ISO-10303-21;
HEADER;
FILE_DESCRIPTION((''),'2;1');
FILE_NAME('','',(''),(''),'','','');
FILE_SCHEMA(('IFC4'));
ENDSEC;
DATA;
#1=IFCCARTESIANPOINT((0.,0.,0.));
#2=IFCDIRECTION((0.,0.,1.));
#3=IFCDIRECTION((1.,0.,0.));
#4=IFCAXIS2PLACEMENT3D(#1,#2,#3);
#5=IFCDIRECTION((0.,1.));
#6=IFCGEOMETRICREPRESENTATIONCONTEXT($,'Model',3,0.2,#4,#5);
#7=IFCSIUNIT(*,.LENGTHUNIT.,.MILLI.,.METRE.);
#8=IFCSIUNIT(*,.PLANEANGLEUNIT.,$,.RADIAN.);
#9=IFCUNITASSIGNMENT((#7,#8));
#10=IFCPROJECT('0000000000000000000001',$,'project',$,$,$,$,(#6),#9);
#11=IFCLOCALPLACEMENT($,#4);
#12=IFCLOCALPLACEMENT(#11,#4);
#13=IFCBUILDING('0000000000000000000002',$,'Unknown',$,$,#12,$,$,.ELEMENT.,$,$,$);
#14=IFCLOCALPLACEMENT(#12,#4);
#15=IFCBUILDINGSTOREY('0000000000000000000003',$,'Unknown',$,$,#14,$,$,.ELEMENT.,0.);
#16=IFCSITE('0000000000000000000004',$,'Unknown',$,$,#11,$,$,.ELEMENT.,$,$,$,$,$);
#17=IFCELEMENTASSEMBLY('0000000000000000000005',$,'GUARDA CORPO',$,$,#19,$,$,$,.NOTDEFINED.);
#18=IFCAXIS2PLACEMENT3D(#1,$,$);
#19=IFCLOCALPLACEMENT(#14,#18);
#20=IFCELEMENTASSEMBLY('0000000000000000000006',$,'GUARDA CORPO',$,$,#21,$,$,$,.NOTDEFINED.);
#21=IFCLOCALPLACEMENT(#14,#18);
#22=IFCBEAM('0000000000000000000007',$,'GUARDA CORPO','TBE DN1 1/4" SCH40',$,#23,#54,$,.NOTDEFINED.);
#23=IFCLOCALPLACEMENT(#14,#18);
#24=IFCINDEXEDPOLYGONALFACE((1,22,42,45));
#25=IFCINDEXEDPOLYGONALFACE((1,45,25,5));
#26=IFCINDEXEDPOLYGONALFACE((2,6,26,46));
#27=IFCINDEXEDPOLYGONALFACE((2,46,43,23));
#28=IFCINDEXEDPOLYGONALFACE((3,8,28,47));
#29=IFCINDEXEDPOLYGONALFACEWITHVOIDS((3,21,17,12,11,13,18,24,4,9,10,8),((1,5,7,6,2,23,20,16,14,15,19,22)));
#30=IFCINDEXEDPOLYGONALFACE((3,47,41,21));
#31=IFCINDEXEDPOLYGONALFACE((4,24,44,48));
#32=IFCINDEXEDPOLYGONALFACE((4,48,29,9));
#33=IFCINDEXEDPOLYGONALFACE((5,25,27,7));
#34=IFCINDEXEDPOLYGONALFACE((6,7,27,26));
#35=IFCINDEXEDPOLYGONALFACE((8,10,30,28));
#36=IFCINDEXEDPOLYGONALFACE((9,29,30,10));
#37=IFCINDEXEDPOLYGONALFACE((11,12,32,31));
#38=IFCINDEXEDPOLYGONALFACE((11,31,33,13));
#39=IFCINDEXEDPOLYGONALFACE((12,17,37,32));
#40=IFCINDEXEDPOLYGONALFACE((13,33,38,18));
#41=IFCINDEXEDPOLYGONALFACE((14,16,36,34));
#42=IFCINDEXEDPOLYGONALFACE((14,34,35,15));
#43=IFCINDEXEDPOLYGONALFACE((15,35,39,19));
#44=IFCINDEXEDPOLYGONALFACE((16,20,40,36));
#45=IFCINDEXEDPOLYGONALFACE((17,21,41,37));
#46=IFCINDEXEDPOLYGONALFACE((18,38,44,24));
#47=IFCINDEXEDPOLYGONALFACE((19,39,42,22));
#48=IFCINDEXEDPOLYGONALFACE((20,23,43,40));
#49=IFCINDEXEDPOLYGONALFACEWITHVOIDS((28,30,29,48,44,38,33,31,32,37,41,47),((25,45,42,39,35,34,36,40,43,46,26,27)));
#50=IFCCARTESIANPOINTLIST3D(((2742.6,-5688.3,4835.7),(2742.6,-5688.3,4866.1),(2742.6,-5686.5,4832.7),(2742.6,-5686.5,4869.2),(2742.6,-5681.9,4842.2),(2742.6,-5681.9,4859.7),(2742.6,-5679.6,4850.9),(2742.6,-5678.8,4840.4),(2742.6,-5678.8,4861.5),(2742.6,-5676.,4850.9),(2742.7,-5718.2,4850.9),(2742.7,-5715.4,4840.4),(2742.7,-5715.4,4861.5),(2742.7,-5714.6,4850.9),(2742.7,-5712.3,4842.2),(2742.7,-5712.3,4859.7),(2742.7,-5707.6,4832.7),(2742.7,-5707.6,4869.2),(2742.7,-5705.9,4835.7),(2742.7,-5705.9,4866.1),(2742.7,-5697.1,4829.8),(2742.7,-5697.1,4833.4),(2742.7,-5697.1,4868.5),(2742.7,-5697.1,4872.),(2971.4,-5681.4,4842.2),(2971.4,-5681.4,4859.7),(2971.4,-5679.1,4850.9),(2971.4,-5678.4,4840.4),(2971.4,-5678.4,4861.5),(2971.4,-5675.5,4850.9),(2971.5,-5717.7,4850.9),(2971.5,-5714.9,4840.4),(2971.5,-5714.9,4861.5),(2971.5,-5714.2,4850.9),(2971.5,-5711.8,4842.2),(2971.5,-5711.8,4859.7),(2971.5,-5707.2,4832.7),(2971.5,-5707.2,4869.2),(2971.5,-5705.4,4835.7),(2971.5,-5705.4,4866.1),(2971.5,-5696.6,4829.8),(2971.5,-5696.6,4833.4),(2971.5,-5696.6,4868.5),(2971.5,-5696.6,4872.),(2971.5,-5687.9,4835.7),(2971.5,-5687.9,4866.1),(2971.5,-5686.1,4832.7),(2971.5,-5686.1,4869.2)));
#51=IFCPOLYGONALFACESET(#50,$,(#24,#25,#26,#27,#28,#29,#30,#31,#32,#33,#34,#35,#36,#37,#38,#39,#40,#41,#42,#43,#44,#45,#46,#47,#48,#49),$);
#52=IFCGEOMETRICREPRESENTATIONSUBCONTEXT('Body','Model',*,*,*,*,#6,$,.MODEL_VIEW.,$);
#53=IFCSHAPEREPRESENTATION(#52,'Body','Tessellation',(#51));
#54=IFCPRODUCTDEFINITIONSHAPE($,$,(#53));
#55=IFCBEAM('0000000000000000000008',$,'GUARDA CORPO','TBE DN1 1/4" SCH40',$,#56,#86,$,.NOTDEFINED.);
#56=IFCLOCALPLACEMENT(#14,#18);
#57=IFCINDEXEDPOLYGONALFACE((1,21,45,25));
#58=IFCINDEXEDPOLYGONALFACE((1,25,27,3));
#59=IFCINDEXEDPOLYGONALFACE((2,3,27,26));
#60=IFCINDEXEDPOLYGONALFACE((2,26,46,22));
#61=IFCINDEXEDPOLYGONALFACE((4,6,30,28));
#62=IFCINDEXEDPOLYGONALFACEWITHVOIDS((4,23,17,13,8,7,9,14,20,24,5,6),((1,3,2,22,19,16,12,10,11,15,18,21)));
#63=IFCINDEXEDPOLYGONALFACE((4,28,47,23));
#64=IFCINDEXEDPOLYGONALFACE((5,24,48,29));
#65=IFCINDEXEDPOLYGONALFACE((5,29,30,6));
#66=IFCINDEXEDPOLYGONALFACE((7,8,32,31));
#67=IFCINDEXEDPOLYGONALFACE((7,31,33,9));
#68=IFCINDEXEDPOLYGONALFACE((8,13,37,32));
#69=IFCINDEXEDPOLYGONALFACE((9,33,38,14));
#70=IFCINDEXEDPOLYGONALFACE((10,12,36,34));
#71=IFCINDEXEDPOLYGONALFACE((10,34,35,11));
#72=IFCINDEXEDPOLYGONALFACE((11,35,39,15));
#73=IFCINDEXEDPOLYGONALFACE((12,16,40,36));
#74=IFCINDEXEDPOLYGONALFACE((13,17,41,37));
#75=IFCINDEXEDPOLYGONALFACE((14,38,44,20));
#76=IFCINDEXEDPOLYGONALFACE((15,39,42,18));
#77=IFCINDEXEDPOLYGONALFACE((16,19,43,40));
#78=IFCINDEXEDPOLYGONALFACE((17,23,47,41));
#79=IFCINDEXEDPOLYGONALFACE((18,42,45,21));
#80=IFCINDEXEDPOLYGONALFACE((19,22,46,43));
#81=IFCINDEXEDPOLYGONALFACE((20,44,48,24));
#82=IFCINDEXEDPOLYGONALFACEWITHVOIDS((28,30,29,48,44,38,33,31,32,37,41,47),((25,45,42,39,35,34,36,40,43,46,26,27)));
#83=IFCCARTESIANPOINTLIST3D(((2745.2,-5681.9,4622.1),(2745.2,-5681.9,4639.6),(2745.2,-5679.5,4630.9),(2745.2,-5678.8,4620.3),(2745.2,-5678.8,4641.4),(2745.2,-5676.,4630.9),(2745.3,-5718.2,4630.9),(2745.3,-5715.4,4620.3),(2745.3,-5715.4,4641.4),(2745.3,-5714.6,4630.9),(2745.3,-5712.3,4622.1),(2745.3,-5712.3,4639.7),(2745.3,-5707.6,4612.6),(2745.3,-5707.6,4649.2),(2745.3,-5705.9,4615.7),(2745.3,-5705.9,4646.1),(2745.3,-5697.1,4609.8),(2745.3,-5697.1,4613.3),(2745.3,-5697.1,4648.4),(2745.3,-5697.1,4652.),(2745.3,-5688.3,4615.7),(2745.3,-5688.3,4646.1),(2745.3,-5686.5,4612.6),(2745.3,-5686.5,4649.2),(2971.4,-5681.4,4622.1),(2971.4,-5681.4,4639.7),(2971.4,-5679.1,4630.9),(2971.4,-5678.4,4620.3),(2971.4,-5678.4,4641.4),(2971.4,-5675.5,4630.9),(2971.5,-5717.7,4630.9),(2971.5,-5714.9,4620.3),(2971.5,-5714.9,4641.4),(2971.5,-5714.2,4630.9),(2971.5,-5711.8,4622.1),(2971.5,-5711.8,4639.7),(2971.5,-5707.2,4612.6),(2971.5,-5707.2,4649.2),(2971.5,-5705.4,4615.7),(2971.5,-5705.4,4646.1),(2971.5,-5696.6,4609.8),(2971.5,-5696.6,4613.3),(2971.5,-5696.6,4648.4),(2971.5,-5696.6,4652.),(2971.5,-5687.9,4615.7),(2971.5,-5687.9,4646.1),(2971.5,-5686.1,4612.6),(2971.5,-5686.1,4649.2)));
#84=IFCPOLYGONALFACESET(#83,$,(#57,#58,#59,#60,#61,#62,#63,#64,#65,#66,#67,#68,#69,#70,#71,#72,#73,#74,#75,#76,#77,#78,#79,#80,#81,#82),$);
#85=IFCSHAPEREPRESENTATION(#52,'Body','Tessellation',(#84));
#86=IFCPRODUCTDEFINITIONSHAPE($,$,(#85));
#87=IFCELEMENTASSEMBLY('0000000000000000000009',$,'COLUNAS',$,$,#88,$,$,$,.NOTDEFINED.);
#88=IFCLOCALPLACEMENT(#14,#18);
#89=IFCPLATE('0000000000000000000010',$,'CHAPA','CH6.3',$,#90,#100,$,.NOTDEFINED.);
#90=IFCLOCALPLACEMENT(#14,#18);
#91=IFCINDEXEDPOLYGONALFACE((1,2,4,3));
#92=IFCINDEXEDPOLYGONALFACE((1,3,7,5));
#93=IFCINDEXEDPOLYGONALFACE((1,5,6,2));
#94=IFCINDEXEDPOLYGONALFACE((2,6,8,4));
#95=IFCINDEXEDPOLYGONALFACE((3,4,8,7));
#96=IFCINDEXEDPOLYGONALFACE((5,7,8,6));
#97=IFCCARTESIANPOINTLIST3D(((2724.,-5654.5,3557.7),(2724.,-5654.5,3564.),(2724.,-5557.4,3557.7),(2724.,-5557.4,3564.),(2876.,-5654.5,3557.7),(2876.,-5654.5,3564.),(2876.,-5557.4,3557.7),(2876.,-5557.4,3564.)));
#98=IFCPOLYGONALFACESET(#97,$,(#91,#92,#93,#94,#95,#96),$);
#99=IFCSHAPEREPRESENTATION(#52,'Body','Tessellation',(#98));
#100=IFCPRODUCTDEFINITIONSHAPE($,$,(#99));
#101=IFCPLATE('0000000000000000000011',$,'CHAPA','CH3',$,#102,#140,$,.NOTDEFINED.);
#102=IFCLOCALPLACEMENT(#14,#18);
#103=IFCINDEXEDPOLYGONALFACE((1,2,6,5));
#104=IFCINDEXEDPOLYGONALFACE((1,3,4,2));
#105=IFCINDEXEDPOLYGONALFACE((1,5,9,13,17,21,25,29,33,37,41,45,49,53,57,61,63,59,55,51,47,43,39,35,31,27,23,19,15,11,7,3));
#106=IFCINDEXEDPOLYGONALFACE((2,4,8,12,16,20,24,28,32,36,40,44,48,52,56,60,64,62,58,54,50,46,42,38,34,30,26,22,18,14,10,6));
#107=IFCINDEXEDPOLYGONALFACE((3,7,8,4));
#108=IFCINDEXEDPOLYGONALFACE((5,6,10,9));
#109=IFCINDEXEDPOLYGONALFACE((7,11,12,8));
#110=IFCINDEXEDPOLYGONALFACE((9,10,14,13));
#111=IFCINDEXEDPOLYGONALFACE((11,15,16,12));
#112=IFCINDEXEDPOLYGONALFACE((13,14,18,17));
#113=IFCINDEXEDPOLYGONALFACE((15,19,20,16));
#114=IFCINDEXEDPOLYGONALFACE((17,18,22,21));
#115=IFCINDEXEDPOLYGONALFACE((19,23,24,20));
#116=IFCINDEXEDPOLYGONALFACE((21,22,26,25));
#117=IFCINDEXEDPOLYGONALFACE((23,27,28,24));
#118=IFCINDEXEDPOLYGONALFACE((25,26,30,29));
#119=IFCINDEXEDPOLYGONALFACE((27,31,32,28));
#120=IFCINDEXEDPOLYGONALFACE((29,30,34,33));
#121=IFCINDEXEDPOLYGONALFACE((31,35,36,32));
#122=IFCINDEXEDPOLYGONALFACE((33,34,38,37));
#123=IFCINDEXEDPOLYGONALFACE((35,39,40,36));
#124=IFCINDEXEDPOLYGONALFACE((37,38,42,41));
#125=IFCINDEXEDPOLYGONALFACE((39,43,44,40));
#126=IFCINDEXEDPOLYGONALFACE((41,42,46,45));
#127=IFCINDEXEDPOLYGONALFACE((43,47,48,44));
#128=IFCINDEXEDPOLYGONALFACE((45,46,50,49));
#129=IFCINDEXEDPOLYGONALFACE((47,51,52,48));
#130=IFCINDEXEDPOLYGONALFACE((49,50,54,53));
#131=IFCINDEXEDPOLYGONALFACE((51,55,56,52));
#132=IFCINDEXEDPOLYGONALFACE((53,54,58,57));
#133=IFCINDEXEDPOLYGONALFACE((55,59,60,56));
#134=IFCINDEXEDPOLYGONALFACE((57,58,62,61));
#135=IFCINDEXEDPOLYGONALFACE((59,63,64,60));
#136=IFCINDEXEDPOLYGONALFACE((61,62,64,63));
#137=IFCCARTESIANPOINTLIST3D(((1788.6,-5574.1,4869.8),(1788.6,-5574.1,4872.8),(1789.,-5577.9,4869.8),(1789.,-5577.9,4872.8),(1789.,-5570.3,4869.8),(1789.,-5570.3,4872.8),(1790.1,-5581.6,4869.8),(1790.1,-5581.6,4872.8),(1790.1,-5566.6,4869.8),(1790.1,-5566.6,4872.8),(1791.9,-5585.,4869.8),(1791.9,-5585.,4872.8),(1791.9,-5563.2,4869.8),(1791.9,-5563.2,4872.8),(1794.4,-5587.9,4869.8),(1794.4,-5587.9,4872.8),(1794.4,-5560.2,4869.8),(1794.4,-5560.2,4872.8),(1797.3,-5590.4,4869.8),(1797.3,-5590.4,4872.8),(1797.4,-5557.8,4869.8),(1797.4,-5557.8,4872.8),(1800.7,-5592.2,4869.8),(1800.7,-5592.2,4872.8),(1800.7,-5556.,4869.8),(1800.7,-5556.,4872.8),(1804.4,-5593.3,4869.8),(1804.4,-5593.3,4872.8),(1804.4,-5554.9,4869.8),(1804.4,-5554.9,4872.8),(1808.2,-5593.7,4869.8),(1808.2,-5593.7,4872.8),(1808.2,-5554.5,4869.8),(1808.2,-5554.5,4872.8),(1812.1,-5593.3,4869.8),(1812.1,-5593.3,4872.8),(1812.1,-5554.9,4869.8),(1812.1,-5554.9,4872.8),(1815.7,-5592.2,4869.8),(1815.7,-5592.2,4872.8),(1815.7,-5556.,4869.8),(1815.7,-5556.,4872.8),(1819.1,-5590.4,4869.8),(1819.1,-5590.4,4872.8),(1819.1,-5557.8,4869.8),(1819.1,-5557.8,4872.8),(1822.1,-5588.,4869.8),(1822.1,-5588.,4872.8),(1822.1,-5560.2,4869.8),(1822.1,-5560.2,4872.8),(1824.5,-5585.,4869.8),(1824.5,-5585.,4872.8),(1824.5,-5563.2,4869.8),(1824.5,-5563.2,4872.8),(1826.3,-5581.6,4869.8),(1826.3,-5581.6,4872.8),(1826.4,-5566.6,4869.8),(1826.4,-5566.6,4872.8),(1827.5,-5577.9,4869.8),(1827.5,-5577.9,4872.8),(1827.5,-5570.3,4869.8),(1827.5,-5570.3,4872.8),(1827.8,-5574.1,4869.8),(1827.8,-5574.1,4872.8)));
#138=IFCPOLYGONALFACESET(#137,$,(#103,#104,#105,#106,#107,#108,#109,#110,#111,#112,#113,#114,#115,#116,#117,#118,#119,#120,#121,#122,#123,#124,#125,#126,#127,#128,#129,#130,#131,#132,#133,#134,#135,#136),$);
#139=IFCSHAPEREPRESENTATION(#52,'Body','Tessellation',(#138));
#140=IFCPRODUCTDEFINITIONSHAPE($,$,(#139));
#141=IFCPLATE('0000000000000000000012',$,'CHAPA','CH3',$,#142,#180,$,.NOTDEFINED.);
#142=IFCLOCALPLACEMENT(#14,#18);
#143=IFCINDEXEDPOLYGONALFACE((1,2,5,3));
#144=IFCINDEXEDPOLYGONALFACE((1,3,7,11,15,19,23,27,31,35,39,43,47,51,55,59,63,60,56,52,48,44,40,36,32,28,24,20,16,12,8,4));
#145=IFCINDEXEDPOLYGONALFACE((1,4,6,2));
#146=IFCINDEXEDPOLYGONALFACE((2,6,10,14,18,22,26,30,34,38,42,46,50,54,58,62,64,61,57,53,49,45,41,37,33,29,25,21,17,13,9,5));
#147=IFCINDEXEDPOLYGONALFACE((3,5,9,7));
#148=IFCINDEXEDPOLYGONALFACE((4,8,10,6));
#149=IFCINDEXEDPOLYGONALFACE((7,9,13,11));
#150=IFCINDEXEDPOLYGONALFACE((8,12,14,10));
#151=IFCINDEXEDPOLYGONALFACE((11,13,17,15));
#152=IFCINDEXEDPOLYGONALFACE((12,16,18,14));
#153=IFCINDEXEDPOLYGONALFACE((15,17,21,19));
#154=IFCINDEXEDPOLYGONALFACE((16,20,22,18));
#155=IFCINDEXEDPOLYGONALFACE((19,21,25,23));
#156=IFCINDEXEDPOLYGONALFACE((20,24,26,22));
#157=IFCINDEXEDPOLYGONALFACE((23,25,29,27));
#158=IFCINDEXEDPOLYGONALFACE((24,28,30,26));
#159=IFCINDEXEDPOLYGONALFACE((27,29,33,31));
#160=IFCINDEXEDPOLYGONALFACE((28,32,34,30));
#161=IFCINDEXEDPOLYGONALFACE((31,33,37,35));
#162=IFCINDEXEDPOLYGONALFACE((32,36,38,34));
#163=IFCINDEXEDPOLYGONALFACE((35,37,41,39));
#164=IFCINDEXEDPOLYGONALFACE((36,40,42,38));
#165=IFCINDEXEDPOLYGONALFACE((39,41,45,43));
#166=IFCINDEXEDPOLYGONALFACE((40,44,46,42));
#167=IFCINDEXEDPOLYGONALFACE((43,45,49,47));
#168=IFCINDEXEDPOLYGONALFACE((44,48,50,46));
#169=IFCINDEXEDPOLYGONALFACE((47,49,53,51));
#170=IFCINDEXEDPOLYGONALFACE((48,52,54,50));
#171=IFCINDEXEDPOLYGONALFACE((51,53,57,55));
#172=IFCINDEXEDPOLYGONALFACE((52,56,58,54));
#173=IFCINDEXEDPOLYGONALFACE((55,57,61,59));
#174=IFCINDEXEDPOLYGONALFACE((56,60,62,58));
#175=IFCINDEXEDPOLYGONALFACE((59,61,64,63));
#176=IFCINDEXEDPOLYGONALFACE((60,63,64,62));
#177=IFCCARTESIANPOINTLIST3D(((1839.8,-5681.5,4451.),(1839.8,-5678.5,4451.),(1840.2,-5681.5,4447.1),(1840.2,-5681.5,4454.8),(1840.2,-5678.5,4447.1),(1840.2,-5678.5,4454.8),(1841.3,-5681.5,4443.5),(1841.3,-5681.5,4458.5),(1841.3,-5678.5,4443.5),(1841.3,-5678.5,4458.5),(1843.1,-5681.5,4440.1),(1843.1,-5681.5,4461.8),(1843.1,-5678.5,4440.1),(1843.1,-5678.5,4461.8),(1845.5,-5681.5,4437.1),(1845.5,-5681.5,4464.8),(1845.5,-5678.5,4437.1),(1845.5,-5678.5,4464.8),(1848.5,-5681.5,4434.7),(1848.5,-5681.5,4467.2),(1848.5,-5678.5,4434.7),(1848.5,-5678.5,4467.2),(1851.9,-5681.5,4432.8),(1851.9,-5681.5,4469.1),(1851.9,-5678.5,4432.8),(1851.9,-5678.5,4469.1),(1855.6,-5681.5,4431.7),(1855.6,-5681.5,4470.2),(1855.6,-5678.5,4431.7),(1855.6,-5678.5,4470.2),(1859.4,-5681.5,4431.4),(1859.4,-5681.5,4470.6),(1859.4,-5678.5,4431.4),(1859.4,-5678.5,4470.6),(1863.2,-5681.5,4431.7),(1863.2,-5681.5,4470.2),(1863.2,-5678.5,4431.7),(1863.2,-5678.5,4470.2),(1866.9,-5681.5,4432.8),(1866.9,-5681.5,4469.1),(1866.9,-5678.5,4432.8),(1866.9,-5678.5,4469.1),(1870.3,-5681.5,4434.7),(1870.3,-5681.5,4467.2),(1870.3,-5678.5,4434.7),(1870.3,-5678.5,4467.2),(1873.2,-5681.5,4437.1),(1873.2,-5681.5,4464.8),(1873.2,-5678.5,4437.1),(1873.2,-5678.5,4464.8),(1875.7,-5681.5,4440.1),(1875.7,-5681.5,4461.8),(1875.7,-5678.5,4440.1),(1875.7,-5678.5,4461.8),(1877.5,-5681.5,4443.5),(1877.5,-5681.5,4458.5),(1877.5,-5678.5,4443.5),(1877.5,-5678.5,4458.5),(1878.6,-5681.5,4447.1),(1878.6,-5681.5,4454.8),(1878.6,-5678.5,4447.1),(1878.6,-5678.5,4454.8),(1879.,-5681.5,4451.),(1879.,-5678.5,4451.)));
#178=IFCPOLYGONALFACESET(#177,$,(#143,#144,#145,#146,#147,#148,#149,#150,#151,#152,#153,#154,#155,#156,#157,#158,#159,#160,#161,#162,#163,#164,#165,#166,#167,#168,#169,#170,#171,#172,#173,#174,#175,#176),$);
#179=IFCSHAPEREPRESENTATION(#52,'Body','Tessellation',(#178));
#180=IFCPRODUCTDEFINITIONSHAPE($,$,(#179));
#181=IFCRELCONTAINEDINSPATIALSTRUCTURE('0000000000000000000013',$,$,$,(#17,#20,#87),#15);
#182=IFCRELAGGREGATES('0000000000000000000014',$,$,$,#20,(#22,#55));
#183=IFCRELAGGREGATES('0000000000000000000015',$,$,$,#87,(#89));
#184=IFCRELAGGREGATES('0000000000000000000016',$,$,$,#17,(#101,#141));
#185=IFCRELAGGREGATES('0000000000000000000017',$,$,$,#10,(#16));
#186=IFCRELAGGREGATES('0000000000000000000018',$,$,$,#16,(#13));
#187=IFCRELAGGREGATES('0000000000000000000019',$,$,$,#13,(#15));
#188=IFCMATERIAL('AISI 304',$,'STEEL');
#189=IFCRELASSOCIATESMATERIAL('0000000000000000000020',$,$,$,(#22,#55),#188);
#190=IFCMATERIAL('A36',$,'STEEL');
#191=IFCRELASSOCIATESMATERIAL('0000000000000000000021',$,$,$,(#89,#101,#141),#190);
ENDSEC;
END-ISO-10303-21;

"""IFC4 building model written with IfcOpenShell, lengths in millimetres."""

from ifc_helpers import new_model, si_unit, direction, frame, origin_with_axes, place, context, subcontext, project, spatial, line, indexed_curve, outline, extrude, material, element, aggregate, save


model = new_model("IFC4")

# Units and contexts
model_context = context("Model", 3, precision=0.2, world=origin_with_axes(), true_north=direction((0.0, 1.0)))
body_context = subcontext(model_context, "Body", "Model", "MODEL_VIEW")
ifc_project = project(units=[si_unit("LENGTHUNIT", "METRE", prefix="MILLI"), si_unit("PLANEANGLEUNIT", "RADIAN")], contexts=[model_context])

# Site, building, storey
site_placement = place(None, origin_with_axes())
site = spatial("IfcSite", under=ifc_project, at=site_placement, Name="Unknown", CompositionType="ELEMENT")
building_placement = place(site_placement, origin_with_axes())
building = spatial("IfcBuilding", under=site, at=building_placement, Name="Unknown", CompositionType="ELEMENT")
storey_placement = place(building_placement, origin_with_axes())
storey = spatial("IfcBuildingStorey", under=building, at=storey_placement, Name="Unknown", CompositionType="ELEMENT", Elevation=0.0)

# Element assemblies, beams
ifc_material_1 = material(Name="A36", Category="STEEL")
assembly_1_placement = place(storey_placement, frame((647.5, -5181.6, 2875.0), z_axis=(-0.000512, 1.0, -0.000003), x_axis=(0.000003, 0.000003, 1.0)))
assembly_1 = element("IfcElementAssembly", 1, at=assembly_1_placement, inside=storey, Name="GUARDA CORPO", PredefinedType="NOTDEFINED")
ifc_material_2 = material(Name="AISI 304", Category="STEEL")
assembly_2_placement = place(storey_placement, frame((2908.2, -5645.6, 3955.0), z_axis=(0.000512, -1.0, -0.000003), x_axis=(0.000003, -0.000003, 1.0)))
assembly_2 = element("IfcElementAssembly", 2, at=assembly_2_placement, inside=storey, Name="GUARDA CORPO", PredefinedType="NOTDEFINED")
beam_1_placement = place(assembly_2_placement, frame((895.9, 165.5, 51.4), z_axis=(-0.000008, 0.001537, -0.999999), x_axis=(0.000004, -0.999999, -0.001537)))
beam_1 = element("IfcBeam", 3, at=beam_1_placement, material=ifc_material_2, Name="GUARDA CORPO", Description="TBE DN1 1/4\" SCH40", PredefinedType="NOTDEFINED", context=body_context, shape_type="SolidModel", body=[
    extrude(outline(indexed_curve([(21.1, 0.0), (18.3, 10.6), (10.6, 18.3), (0.0, 21.1), (-10.6, 18.3), (-18.3, 10.6), (-21.1, 0.0), (-18.3, -10.6), (-10.6, -18.3), (0.0, -21.1), (10.6, -18.3), (18.3, -10.6)], segments=[line(1, 2, 3, 4, 5, 6, 7, 8, 9, 10, 11, 12, 1)]), holes=[indexed_curve([(17.5, 0.0), (15.2, -8.8), (8.8, -15.2), (0.0, -17.5), (-8.8, -15.2), (-15.2, -8.8), (-17.5, 0.0), (-15.2, 8.8), (-8.8, 15.2), (0.0, 17.5), (8.8, 15.2), (15.2, 8.8)], segments=[line(1, 2, 3, 4, 5, 6, 7, 8, 9, 10, 11, 12, 1)])]), frame((0.0, 0.0, 0.0), z_axis=(-1.0, 0.0, 0.0), x_axis=(0.0, 0.0, 1.0)), (0.0, 0.0, -1.0), 228.8),
])
beam_2_placement = place(assembly_2_placement, frame((675.9, 162.9, 51.4), z_axis=(-0.000008, 0.001537, -0.999999), x_axis=(0.000004, -0.999999, -0.001537)))
beam_2 = element("IfcBeam", 4, at=beam_2_placement, material=ifc_material_2, Name="GUARDA CORPO", Description="TBE DN1 1/4\" SCH40", PredefinedType="NOTDEFINED", context=body_context, shape_type="SolidModel", body=[
    extrude(outline(indexed_curve([(21.1, 0.0), (18.3, 10.6), (10.6, 18.3), (0.0, 21.1), (-10.6, 18.3), (-18.3, 10.6), (-21.1, 0.0), (-18.3, -10.6), (-10.6, -18.3), (0.0, -21.1), (10.6, -18.3), (18.3, -10.6)], segments=[line(1, 2, 3, 4, 5, 6, 7, 8, 9, 10, 11, 12, 1)]), holes=[indexed_curve([(17.5, 0.0), (15.2, -8.8), (8.8, -15.2), (0.0, -17.5), (-8.8, -15.2), (-15.2, -8.8), (-17.5, 0.0), (-15.2, 8.8), (-8.8, 15.2), (0.0, 17.5), (8.8, 15.2), (15.2, 8.8)], segments=[line(1, 2, 3, 4, 5, 6, 7, 8, 9, 10, 11, 12, 1)])]), frame((0.0, 0.0, 0.0), z_axis=(-1.0, 0.0, 0.0), x_axis=(0.0, 0.0, 1.0)), (0.0, 0.0, -1.0), 226.2),
])
aggregate(assembly_2, [beam_1, beam_2])

# Element assembly, plate
assembly_3_placement = place(storey_placement, frame((2800.0, -5581.0, 3557.7), z_axis=(-1.0, 0.0, 0.0), x_axis=(0.0, 0.0, -1.0)))
assembly_3 = element("IfcElementAssembly", 5, at=assembly_3_placement, inside=storey, Name="COLUNAS", PredefinedType="NOTDEFINED")
plate_1_placement = place(assembly_3_placement, frame((-3.1, -23.6, 76.0), z_axis=(-1.0, 0.0, 0.0), x_axis=(0.0, 1.0, 0.0)))
plate_1 = element("IfcPlate", 6, at=plate_1_placement, material=ifc_material_1, Name="CHAPA", Description="CH6.3", PredefinedType="NOTDEFINED", context=body_context, shape_type="SolidModel", body=[
    extrude(outline(indexed_curve([(0.0, 0.0), (97.1, 0.0), (97.1, 152.0), (0.0, 152.0)], segments=[line(1, 2, 3, 4, 1)])), frame((0.0, 0.0, 3.1), z_axis=(0.0, 0.0, 1.0), x_axis=(1.0, 0.0, 0.0)), (0.0, 0.0, -1.0), 6.3),
])
aggregate(assembly_3, [plate_1])

# Plates
plate_2_placement = place(assembly_1_placement, frame((1996.3, 1164.3, -412.3), z_axis=(1.0, 0.0, 0.0), x_axis=(0.0, 0.957237, 0.289304)))
plate_2 = element("IfcPlate", 7, at=plate_2_placement, material=ifc_material_1, Name="CHAPA", Description="CH3", PredefinedType="NOTDEFINED", context=body_context, shape_type="SolidModel", body=[
    extrude(outline(indexed_curve([(0.0, 0.0), (3.8, 0.0), (7.6, 0.7), (11.2, 2.2), (14.4, 4.4), (17.1, 7.1), (19.2, 10.3), (20.7, 13.8), (21.4, 17.6), (21.4, 21.4), (20.7, 25.2), (19.2, 28.7), (17.1, 31.9), (14.4, 34.7), (11.2, 36.8), (7.6, 38.3), (3.8, 39.0), (0.0, 39.0), (-3.8, 38.3), (-7.3, 36.8), (-10.5, 34.7), (-13.2, 31.9), (-15.4, 28.7), (-16.8, 25.2), (-17.6, 21.4), (-17.6, 17.6), (-16.8, 13.8), (-15.4, 10.3), (-13.2, 7.1), (-10.5, 4.4), (-7.3, 2.2), (-3.8, 0.7)], segments=[line(1, 2, 3, 4, 5, 6, 7, 8, 9, 10, 11, 12, 13, 14, 15, 16, 17, 18, 19, 20, 21, 22, 23, 24, 25, 26, 27, 28, 29, 30, 31, 32, 1)])), frame((0.0, 0.0, 1.5), z_axis=(0.0, 0.0, 1.0), x_axis=(1.0, 0.0, 0.0)), (0.0, 0.0, -1.0), 3.0),
])
plate_3_placement = place(assembly_1_placement, frame((1556.7, 1215.4, -499.0), z_axis=(-0.000004, -0.000512, -1.0), x_axis=(0.290288, 0.956939, -0.000492)))
plate_3 = element("IfcPlate", 8, at=plate_3_placement, material=ifc_material_1, Name="CHAPA", Description="CH3", PredefinedType="NOTDEFINED", context=body_context, shape_type="SolidModel", body=[
    extrude(outline(indexed_curve([(0.0, 0.0), (3.8, 0.0), (7.6, 0.7), (11.2, 2.2), (14.4, 4.4), (17.1, 7.1), (19.2, 10.3), (20.7, 13.8), (21.4, 17.6), (21.4, 21.4), (20.7, 25.2), (19.2, 28.7), (17.1, 31.9), (14.4, 34.7), (11.2, 36.8), (7.6, 38.3), (3.8, 39.0), (0.0, 39.0), (-3.8, 38.3), (-7.3, 36.8), (-10.5, 34.7), (-13.2, 31.9), (-15.4, 28.7), (-16.8, 25.2), (-17.6, 21.4), (-17.6, 17.6), (-16.8, 13.8), (-15.4, 10.3), (-13.2, 7.1), (-10.5, 4.4), (-7.3, 2.2), (-3.8, 0.7)], segments=[line(1, 2, 3, 4, 5, 6, 7, 8, 9, 10, 11, 12, 13, 14, 15, 16, 17, 18, 19, 20, 21, 22, 23, 24, 25, 26, 27, 28, 29, 30, 31, 32, 1)])), frame((0.0, 0.0, 1.5), z_axis=(0.0, 0.0, 1.0), x_axis=(1.0, 0.0, 0.0)), (0.0, 0.0, -1.0), 3.0),
])

aggregate(assembly_1, [plate_2, plate_3])

save(model, "model.ifc")
